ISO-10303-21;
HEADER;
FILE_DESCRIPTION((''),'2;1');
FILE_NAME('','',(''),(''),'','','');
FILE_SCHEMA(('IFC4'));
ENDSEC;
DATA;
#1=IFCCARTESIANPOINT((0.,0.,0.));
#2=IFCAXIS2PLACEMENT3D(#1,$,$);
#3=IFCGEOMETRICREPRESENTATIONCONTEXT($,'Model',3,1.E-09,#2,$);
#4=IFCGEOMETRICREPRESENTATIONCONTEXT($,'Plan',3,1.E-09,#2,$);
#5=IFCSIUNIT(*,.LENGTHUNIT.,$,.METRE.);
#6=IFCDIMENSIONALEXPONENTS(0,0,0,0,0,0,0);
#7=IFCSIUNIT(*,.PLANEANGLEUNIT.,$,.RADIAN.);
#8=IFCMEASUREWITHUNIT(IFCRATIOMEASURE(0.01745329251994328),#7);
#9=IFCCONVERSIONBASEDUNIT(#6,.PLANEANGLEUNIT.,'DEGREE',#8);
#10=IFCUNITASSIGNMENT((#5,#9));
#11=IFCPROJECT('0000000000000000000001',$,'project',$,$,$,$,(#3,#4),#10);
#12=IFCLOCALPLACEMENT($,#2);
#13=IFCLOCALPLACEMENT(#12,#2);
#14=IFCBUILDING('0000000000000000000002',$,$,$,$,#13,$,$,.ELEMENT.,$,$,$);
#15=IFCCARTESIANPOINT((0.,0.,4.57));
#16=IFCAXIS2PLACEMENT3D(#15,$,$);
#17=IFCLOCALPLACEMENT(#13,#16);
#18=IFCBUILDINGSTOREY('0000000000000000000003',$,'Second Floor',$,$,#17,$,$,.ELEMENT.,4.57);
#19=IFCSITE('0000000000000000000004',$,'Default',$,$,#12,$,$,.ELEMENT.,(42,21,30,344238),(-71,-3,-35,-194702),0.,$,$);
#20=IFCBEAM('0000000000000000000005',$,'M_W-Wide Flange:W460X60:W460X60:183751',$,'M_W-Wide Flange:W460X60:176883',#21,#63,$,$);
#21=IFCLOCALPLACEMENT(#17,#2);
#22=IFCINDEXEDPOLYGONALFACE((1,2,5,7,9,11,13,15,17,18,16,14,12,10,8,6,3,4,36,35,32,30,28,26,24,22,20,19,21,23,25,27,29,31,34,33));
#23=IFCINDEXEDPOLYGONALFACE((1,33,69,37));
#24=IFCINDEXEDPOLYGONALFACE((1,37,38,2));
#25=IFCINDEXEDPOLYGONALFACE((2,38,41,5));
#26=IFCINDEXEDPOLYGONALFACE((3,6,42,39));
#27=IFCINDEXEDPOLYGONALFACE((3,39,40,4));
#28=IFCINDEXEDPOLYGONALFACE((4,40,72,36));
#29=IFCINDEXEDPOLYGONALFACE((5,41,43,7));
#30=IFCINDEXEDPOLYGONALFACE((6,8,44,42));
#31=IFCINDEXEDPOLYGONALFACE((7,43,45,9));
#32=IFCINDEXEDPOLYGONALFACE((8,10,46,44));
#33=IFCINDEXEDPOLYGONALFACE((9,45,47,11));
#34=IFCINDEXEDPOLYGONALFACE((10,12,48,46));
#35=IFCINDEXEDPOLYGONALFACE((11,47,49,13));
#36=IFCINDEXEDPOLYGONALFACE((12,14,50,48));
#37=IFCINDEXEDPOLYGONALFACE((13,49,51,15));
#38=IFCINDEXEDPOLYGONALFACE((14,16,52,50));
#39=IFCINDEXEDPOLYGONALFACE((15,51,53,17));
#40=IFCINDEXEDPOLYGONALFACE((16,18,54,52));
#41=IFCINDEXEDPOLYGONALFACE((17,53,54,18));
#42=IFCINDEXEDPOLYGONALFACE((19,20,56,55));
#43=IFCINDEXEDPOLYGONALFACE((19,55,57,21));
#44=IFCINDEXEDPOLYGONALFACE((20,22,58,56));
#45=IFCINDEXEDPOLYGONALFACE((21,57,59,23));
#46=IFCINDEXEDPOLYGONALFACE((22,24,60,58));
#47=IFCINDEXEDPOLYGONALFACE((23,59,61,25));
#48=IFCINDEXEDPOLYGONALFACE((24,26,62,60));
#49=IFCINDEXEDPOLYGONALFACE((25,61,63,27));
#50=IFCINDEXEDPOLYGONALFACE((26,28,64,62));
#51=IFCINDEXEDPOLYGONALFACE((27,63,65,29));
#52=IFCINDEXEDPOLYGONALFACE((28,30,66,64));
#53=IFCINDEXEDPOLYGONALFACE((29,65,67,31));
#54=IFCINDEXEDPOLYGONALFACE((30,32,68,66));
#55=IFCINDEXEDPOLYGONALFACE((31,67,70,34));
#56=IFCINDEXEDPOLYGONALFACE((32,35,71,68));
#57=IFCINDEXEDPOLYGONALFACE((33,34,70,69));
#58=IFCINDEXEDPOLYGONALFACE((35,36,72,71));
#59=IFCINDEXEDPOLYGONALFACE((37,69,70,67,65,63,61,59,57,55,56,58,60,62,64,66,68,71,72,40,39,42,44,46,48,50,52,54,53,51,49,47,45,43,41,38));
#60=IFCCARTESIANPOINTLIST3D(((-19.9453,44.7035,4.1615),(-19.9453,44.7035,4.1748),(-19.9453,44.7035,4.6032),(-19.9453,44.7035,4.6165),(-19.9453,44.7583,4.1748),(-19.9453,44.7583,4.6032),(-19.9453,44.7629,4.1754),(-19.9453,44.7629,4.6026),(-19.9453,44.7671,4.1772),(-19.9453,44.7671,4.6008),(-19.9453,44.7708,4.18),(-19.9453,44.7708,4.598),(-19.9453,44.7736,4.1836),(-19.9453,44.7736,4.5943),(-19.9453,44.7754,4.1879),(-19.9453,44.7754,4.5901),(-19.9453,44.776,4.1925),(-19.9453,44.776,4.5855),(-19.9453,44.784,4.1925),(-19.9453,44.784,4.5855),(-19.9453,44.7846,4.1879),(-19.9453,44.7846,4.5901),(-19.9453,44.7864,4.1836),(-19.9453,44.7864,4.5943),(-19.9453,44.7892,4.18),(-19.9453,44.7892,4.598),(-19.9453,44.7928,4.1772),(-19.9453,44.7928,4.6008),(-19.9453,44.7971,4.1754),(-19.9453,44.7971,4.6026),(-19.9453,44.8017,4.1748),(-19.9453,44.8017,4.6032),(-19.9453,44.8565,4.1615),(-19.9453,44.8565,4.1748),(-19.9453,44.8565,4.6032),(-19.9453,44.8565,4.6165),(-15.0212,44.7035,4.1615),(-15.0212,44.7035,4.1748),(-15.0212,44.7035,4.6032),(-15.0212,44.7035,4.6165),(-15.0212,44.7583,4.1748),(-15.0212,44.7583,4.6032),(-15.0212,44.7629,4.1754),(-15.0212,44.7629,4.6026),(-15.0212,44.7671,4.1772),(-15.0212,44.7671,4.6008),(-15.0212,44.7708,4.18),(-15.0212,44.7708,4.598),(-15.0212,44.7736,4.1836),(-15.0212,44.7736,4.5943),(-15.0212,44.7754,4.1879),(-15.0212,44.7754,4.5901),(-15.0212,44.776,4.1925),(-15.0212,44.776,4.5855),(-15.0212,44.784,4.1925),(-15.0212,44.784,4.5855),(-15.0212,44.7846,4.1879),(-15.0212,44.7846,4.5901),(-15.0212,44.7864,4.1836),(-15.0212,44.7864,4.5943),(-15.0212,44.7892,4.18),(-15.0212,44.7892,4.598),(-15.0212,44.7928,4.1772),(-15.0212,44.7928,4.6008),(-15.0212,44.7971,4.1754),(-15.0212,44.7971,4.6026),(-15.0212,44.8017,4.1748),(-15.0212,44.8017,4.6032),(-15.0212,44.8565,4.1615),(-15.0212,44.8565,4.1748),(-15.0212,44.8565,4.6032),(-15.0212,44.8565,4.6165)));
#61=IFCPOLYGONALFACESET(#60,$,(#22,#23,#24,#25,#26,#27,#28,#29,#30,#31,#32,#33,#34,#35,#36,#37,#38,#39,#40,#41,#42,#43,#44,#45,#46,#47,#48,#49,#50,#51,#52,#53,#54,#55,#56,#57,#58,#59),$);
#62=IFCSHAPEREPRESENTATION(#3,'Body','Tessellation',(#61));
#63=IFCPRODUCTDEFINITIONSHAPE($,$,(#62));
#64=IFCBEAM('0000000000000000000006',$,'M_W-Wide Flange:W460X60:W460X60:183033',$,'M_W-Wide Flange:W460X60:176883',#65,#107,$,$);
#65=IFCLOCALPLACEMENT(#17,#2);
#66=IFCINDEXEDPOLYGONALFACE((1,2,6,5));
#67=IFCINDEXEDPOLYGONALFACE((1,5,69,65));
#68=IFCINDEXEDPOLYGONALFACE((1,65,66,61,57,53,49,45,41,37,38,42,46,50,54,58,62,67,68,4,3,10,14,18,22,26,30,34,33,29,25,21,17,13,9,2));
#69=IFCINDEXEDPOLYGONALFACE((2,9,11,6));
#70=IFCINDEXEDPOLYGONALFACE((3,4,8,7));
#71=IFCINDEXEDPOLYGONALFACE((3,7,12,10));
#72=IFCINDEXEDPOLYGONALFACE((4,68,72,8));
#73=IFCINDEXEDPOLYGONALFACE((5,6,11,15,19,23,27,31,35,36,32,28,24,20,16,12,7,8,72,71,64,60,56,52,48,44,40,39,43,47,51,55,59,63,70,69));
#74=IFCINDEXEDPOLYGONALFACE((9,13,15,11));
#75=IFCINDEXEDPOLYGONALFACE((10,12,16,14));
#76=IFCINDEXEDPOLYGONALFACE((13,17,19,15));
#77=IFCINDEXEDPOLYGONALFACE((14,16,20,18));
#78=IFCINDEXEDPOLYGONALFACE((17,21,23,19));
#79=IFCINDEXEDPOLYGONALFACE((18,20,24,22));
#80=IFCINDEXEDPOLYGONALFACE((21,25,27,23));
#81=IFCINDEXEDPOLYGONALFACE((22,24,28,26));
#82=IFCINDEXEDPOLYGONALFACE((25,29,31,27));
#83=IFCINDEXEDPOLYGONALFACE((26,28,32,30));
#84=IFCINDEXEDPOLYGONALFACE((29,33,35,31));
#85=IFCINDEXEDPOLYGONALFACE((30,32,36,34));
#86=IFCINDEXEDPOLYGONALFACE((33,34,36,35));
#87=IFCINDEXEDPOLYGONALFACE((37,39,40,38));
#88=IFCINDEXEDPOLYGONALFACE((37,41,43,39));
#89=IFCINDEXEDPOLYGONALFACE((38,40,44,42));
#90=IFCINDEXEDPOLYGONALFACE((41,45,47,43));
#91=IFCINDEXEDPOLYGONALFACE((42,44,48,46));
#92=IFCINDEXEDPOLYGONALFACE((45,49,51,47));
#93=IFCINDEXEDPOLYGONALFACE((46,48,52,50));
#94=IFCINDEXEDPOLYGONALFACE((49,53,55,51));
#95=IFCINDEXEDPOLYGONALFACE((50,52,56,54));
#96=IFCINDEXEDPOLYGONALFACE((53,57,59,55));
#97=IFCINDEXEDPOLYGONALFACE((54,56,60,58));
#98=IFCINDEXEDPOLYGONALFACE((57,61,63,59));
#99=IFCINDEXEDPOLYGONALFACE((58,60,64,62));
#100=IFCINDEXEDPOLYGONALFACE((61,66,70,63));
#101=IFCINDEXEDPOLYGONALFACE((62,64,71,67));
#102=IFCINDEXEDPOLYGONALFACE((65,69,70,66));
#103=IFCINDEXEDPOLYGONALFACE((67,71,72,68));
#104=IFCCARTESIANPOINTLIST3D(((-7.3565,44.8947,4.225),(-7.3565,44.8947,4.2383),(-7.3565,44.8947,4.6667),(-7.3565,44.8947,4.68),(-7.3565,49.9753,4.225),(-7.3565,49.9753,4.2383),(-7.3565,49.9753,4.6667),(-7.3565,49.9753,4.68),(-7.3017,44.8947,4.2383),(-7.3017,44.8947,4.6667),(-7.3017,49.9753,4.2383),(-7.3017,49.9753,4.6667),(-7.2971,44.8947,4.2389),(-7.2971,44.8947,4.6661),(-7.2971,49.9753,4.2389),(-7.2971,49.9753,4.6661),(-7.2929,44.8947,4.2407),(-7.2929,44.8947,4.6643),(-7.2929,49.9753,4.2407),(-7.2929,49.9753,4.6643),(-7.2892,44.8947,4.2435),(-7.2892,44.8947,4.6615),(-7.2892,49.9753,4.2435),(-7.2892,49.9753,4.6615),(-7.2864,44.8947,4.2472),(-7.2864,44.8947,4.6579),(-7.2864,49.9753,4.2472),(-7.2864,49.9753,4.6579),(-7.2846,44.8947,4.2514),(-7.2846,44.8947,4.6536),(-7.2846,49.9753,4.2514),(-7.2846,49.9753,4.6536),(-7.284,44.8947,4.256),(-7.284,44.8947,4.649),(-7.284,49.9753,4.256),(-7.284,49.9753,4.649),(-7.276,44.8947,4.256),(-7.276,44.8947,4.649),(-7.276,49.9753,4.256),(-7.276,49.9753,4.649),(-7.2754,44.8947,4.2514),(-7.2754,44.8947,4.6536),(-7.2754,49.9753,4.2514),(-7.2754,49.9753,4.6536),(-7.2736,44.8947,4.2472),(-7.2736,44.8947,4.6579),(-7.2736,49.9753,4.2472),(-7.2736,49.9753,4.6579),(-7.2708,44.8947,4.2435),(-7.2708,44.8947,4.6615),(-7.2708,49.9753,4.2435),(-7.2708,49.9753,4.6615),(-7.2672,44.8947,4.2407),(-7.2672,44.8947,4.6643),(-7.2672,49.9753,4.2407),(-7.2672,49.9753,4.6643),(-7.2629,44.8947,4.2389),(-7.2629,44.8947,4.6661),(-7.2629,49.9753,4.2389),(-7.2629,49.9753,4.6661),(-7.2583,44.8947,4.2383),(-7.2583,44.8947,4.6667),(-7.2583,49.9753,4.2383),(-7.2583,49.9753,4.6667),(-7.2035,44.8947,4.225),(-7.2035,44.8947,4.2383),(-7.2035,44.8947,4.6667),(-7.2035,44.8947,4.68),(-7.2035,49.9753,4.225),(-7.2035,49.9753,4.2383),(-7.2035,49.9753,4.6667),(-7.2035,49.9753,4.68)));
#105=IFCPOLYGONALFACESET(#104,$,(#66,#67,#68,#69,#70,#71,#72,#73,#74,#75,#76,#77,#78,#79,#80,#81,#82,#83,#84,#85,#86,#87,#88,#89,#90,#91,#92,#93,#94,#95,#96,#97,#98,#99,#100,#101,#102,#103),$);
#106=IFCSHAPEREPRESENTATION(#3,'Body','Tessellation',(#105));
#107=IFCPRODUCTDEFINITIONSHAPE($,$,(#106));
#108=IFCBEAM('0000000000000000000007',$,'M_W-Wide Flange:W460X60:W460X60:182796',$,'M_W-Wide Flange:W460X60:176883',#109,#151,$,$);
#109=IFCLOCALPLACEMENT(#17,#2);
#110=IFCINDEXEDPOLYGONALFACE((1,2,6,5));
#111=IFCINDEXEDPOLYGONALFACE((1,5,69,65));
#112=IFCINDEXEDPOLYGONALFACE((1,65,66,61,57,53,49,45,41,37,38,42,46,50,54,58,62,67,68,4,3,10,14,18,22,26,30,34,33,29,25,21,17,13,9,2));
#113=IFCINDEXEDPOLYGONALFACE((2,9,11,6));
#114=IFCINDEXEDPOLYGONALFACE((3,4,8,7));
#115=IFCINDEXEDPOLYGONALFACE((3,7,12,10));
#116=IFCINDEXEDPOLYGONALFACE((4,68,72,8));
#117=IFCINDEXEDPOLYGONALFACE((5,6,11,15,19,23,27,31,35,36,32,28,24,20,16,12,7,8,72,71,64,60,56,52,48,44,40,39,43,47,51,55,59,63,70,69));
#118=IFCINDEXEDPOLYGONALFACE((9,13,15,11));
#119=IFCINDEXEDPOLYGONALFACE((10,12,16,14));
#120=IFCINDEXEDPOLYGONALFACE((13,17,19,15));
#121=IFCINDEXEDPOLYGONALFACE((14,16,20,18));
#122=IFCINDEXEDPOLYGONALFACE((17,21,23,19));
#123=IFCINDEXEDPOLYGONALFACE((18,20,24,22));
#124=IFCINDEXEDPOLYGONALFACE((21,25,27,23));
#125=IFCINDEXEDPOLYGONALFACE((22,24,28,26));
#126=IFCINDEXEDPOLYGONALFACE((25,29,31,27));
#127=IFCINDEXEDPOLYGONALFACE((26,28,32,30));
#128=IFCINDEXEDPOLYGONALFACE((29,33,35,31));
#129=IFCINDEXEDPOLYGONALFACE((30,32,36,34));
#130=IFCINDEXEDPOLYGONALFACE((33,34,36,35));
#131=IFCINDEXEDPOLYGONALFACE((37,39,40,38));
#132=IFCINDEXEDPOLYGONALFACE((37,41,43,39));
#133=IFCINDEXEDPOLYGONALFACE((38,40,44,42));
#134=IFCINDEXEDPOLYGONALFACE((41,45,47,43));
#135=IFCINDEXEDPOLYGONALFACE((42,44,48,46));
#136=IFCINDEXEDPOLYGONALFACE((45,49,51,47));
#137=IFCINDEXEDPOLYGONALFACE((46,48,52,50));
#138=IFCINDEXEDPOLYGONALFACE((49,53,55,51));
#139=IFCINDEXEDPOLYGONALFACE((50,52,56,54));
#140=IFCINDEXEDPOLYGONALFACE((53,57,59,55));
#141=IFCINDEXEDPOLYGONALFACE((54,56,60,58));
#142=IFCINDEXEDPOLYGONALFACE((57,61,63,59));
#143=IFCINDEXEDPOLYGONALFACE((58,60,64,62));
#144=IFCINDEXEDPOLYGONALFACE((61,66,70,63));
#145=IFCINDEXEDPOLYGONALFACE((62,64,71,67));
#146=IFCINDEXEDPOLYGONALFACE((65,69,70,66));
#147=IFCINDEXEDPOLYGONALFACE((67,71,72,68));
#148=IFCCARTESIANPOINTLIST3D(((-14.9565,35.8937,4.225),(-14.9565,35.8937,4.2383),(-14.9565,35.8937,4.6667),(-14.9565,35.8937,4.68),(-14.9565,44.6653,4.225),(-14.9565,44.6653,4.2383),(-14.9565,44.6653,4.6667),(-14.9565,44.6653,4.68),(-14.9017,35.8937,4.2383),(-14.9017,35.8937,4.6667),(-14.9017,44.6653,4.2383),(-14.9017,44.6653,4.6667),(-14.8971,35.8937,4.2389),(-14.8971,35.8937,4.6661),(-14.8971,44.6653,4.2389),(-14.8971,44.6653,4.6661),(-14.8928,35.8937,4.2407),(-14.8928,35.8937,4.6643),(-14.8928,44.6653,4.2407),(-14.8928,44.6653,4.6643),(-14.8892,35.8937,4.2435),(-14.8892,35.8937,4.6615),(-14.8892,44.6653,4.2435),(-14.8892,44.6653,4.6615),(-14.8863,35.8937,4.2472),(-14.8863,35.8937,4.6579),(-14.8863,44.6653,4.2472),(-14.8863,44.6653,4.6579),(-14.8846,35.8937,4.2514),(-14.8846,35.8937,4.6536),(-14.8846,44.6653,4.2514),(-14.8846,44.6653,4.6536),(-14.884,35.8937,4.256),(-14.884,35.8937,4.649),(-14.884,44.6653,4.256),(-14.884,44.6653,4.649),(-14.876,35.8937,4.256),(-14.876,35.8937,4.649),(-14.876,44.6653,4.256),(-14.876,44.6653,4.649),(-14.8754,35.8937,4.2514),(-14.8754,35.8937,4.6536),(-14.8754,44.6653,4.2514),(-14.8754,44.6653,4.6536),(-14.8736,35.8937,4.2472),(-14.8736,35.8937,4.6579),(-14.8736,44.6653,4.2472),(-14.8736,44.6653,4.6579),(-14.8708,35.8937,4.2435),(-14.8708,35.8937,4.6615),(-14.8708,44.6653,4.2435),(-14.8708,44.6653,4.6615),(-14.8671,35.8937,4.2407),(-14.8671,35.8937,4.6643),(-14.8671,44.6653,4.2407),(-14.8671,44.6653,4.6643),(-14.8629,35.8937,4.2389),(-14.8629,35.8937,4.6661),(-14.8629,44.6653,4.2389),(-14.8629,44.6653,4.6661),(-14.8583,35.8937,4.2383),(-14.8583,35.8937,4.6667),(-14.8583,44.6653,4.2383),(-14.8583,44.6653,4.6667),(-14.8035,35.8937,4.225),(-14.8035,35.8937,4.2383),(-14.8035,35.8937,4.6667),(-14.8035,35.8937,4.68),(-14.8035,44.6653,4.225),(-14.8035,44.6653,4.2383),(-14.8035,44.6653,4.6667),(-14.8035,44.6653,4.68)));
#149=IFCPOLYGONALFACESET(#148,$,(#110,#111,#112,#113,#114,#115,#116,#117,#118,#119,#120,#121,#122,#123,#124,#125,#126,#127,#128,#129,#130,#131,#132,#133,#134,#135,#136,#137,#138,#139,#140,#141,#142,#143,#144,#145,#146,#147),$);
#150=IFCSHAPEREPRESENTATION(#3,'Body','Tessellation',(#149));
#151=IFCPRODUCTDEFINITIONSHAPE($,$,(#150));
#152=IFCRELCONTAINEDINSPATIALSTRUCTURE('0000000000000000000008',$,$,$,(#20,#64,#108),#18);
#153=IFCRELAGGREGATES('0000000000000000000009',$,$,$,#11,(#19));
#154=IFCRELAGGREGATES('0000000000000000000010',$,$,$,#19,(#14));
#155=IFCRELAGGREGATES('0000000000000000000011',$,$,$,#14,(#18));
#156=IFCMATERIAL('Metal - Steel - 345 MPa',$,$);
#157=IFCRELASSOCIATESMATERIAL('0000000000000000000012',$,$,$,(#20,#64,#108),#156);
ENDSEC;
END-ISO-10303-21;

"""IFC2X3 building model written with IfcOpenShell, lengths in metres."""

from ifc_helpers import new_model, entity, si_unit, converted_unit, frame, frame_2d, origin, place, context, project, spatial, polyline, circle_curve, parameter, trimmed, segment, composite_curve, outline, extrude, material, element, save


model = new_model("IFC2X3")

# Units and contexts
model_context = context("Model", 3, precision=1e-09, world=origin())
plan_context = context("Plan", 3, precision=1e-09, world=origin())
ifc_project = project(units=[si_unit("LENGTHUNIT", "METRE"), converted_unit("PLANEANGLEUNIT", "DEGREE", entity("IfcRatioMeasure", 0.01745329251994328), si_unit("PLANEANGLEUNIT", "RADIAN"), dimensions=[0, 0, 0, 0, 0, 0, 0])], contexts=[model_context, plan_context])

# Site, building, storey
site_placement = place(None, origin())
site = spatial("IfcSite", under=ifc_project, at=site_placement, Name="Default", CompositionType="ELEMENT", RefLatitude=(42, 21, 30, 344238), RefLongitude=(-71, -3, -35, -194702), RefElevation=0.0)
building_placement = place(site_placement, origin())
building = spatial("IfcBuilding", under=site, at=building_placement, CompositionType="ELEMENT")
storey_placement = place(building_placement, frame((0.0, 0.0, 4.57)))
storey = spatial("IfcBuildingStorey", under=building, at=storey_placement, Name="Second Floor", CompositionType="ELEMENT", Elevation=4.57)

# Shared definitions
ifc_material = material(Name="Metal - Steel - 345 MPa")

# Beams
beam_1_placement = place(storey_placement, frame((-20.0564, 44.78, 4.6165), z_axis=(0.0, 0.0, 1.0), x_axis=(0.0, -1.0, 0.0)))
element("IfcBeam", 1, at=beam_1_placement, inside=storey, material=ifc_material, Name="M_W-Wide Flange:W460X60:W460X60:183751", ObjectType="M_W-Wide Flange:W460X60:176883", context=model_context, shape_type="SweptSolid", body=[
    extrude(outline(composite_curve([segment(polyline([(-0.0765, -0.2142), (-0.0765, -0.2275)]), True, "CONTINUOUS"), segment(polyline([(-0.0765, -0.2275), (0.0765, -0.2275)]), True, "CONTINUOUS"), segment(polyline([(0.0765, -0.2275), (0.0765, -0.2142)]), True, "CONTINUOUS"), segment(polyline([(0.0765, -0.2142), (0.0217, -0.2142)]), True, "CONTINUOUS"), segment(trimmed(circle_curve(frame_2d((0.0217, -0.1965), x_axis=(0.0, -1.0)), 0.0177), [parameter(270.0)], [parameter(360.0)], True, "PARAMETER"), False, "CONTINUOUS"), segment(polyline([(0.004, -0.1965), (0.004, 0.1965)]), True, "CONTINUOUS"), segment(trimmed(circle_curve(frame_2d((0.0217, 0.1965), x_axis=(-1.0, 0.0)), 0.0177), [parameter(270.0)], [parameter(360.0)], True, "PARAMETER"), False, "CONTINUOUS"), segment(polyline([(0.0217, 0.2142), (0.0765, 0.2142)]), True, "CONTINUOUS"), segment(polyline([(0.0765, 0.2142), (0.0765, 0.2275)]), True, "CONTINUOUS"), segment(polyline([(0.0765, 0.2275), (-0.0765, 0.2275)]), True, "CONTINUOUS"), segment(polyline([(-0.0765, 0.2275), (-0.0765, 0.2142)]), True, "CONTINUOUS"), segment(polyline([(-0.0765, 0.2142), (-0.0217, 0.2142)]), True, "CONTINUOUS"), segment(trimmed(circle_curve(frame_2d((-0.0217, 0.1965), x_axis=(0.0, 1.0)), 0.0177), [parameter(270.0)], [parameter(360.0)], True, "PARAMETER"), False, "CONTINUOUS"), segment(polyline([(-0.004, 0.1965), (-0.004, -0.1965)]), True, "CONTINUOUS"), segment(trimmed(circle_curve(frame_2d((-0.0217, -0.1965), x_axis=(1.0, 0.0)), 0.0177), [parameter(270.0)], [parameter(0.0)], True, "PARAMETER"), False, "CONTINUOUS"), segment(polyline([(-0.0217, -0.2142), (-0.0765, -0.2142)]), True, "CONTINUOUS")], self_intersect=False)), frame((0.0, 0.1111, -0.2275), z_axis=(0.0, -1.0, 0.0), x_axis=(1.0, 0.0, 0.0)), (0.0, 0.0, -1.0), 4.9241),
])
beam_2_placement = place(storey_placement, frame((-7.28, 44.7836, 4.68)))
element("IfcBeam", 2, at=beam_2_placement, inside=storey, material=ifc_material, Name="M_W-Wide Flange:W460X60:W460X60:183033", ObjectType="M_W-Wide Flange:W460X60:176883", context=model_context, shape_type="SweptSolid", body=[
    extrude(outline(composite_curve([segment(polyline([(-0.0765, -0.2142), (-0.0765, -0.2275)]), True, "CONTINUOUS"), segment(polyline([(-0.0765, -0.2275), (0.0765, -0.2275)]), True, "CONTINUOUS"), segment(polyline([(0.0765, -0.2275), (0.0765, -0.2142)]), True, "CONTINUOUS"), segment(polyline([(0.0765, -0.2142), (0.0217, -0.2142)]), True, "CONTINUOUS"), segment(trimmed(circle_curve(frame_2d((0.0217, -0.1965), x_axis=(0.0, -1.0)), 0.0177), [parameter(270.0)], [parameter(360.0)], True, "PARAMETER"), False, "CONTINUOUS"), segment(polyline([(0.004, -0.1965), (0.004, 0.1965)]), True, "CONTINUOUS"), segment(trimmed(circle_curve(frame_2d((0.0217, 0.1965), x_axis=(-1.0, 0.0)), 0.0177), [parameter(270.0)], [parameter(360.0)], True, "PARAMETER"), False, "CONTINUOUS"), segment(polyline([(0.0217, 0.2142), (0.0765, 0.2142)]), True, "CONTINUOUS"), segment(polyline([(0.0765, 0.2142), (0.0765, 0.2275)]), True, "CONTINUOUS"), segment(polyline([(0.0765, 0.2275), (-0.0765, 0.2275)]), True, "CONTINUOUS"), segment(polyline([(-0.0765, 0.2275), (-0.0765, 0.2142)]), True, "CONTINUOUS"), segment(polyline([(-0.0765, 0.2142), (-0.0217, 0.2142)]), True, "CONTINUOUS"), segment(trimmed(circle_curve(frame_2d((-0.0217, 0.1965), x_axis=(0.0, 1.0)), 0.0177), [parameter(270.0)], [parameter(360.0)], True, "PARAMETER"), False, "CONTINUOUS"), segment(polyline([(-0.004, 0.1965), (-0.004, -0.1965)]), True, "CONTINUOUS"), segment(trimmed(circle_curve(frame_2d((-0.0217, -0.1965), x_axis=(1.0, 0.0)), 0.0177), [parameter(270.0)], [parameter(0.0)], True, "PARAMETER"), False, "CONTINUOUS"), segment(polyline([(-0.0217, -0.2142), (-0.0765, -0.2142)]), True, "CONTINUOUS")], self_intersect=False)), frame((0.0, 0.1111, -0.2275), z_axis=(0.0, -1.0, 0.0), x_axis=(1.0, 0.0, 0.0)), (0.0, 0.0, -1.0), 5.0806),
])
beam_3_placement = place(storey_placement, frame((-14.88, 44.7781, 4.68), z_axis=(0.0, 0.0, 1.0), x_axis=(-1.0, 0.0, 0.0)))
element("IfcBeam", 3, at=beam_3_placement, inside=storey, material=ifc_material, Name="M_W-Wide Flange:W460X60:W460X60:182796", ObjectType="M_W-Wide Flange:W460X60:176883", context=model_context, shape_type="SweptSolid", body=[
    extrude(outline(composite_curve([segment(polyline([(0.2142, -0.0765), (0.2275, -0.0765)]), True, "CONTINUOUS"), segment(polyline([(0.2275, -0.0765), (0.2275, 0.0765)]), True, "CONTINUOUS"), segment(polyline([(0.2275, 0.0765), (0.2142, 0.0765)]), True, "CONTINUOUS"), segment(polyline([(0.2142, 0.0765), (0.2142, 0.0217)]), True, "CONTINUOUS"), segment(trimmed(circle_curve(frame_2d((0.1965, 0.0217), x_axis=(0.0, 1.0)), 0.0177), [parameter(180.0)], [parameter(270.0)], True, "PARAMETER"), False, "CONTINUOUS"), segment(polyline([(0.1965, 0.004), (-0.1965, 0.004)]), True, "CONTINUOUS"), segment(trimmed(circle_curve(frame_2d((-0.1965, 0.0217), x_axis=(0.0, 1.0)), 0.0177), [parameter(90.0)], [parameter(180.0)], True, "PARAMETER"), False, "CONTINUOUS"), segment(polyline([(-0.2142, 0.0217), (-0.2142, 0.0765)]), True, "CONTINUOUS"), segment(polyline([(-0.2142, 0.0765), (-0.2275, 0.0765)]), True, "CONTINUOUS"), segment(polyline([(-0.2275, 0.0765), (-0.2275, -0.0765)]), True, "CONTINUOUS"), segment(polyline([(-0.2275, -0.0765), (-0.2142, -0.0765)]), True, "CONTINUOUS"), segment(polyline([(-0.2142, -0.0765), (-0.2142, -0.0217)]), True, "CONTINUOUS"), segment(trimmed(circle_curve(frame_2d((-0.1965, -0.0217), x_axis=(0.0, 1.0)), 0.0177), [parameter(360.0)], [parameter(90.0)], True, "PARAMETER"), False, "CONTINUOUS"), segment(polyline([(-0.1965, -0.004), (0.1965, -0.004)]), True, "CONTINUOUS"), segment(trimmed(circle_curve(frame_2d((0.1965, -0.0217), x_axis=(0.0, 1.0)), 0.0177), [parameter(270.0)], [parameter(0.0)], True, "PARAMETER"), False, "CONTINUOUS"), segment(polyline([(0.2142, -0.0217), (0.2142, -0.0765)]), True, "CONTINUOUS")], self_intersect=False)), frame((0.0, 8.8844, -0.2275), z_axis=(0.0, -1.0, 0.0), x_axis=(0.0, 0.0, -1.0)), (0.0, 0.0, 1.0), 8.7716),
])

save(model, "model.ifc")
